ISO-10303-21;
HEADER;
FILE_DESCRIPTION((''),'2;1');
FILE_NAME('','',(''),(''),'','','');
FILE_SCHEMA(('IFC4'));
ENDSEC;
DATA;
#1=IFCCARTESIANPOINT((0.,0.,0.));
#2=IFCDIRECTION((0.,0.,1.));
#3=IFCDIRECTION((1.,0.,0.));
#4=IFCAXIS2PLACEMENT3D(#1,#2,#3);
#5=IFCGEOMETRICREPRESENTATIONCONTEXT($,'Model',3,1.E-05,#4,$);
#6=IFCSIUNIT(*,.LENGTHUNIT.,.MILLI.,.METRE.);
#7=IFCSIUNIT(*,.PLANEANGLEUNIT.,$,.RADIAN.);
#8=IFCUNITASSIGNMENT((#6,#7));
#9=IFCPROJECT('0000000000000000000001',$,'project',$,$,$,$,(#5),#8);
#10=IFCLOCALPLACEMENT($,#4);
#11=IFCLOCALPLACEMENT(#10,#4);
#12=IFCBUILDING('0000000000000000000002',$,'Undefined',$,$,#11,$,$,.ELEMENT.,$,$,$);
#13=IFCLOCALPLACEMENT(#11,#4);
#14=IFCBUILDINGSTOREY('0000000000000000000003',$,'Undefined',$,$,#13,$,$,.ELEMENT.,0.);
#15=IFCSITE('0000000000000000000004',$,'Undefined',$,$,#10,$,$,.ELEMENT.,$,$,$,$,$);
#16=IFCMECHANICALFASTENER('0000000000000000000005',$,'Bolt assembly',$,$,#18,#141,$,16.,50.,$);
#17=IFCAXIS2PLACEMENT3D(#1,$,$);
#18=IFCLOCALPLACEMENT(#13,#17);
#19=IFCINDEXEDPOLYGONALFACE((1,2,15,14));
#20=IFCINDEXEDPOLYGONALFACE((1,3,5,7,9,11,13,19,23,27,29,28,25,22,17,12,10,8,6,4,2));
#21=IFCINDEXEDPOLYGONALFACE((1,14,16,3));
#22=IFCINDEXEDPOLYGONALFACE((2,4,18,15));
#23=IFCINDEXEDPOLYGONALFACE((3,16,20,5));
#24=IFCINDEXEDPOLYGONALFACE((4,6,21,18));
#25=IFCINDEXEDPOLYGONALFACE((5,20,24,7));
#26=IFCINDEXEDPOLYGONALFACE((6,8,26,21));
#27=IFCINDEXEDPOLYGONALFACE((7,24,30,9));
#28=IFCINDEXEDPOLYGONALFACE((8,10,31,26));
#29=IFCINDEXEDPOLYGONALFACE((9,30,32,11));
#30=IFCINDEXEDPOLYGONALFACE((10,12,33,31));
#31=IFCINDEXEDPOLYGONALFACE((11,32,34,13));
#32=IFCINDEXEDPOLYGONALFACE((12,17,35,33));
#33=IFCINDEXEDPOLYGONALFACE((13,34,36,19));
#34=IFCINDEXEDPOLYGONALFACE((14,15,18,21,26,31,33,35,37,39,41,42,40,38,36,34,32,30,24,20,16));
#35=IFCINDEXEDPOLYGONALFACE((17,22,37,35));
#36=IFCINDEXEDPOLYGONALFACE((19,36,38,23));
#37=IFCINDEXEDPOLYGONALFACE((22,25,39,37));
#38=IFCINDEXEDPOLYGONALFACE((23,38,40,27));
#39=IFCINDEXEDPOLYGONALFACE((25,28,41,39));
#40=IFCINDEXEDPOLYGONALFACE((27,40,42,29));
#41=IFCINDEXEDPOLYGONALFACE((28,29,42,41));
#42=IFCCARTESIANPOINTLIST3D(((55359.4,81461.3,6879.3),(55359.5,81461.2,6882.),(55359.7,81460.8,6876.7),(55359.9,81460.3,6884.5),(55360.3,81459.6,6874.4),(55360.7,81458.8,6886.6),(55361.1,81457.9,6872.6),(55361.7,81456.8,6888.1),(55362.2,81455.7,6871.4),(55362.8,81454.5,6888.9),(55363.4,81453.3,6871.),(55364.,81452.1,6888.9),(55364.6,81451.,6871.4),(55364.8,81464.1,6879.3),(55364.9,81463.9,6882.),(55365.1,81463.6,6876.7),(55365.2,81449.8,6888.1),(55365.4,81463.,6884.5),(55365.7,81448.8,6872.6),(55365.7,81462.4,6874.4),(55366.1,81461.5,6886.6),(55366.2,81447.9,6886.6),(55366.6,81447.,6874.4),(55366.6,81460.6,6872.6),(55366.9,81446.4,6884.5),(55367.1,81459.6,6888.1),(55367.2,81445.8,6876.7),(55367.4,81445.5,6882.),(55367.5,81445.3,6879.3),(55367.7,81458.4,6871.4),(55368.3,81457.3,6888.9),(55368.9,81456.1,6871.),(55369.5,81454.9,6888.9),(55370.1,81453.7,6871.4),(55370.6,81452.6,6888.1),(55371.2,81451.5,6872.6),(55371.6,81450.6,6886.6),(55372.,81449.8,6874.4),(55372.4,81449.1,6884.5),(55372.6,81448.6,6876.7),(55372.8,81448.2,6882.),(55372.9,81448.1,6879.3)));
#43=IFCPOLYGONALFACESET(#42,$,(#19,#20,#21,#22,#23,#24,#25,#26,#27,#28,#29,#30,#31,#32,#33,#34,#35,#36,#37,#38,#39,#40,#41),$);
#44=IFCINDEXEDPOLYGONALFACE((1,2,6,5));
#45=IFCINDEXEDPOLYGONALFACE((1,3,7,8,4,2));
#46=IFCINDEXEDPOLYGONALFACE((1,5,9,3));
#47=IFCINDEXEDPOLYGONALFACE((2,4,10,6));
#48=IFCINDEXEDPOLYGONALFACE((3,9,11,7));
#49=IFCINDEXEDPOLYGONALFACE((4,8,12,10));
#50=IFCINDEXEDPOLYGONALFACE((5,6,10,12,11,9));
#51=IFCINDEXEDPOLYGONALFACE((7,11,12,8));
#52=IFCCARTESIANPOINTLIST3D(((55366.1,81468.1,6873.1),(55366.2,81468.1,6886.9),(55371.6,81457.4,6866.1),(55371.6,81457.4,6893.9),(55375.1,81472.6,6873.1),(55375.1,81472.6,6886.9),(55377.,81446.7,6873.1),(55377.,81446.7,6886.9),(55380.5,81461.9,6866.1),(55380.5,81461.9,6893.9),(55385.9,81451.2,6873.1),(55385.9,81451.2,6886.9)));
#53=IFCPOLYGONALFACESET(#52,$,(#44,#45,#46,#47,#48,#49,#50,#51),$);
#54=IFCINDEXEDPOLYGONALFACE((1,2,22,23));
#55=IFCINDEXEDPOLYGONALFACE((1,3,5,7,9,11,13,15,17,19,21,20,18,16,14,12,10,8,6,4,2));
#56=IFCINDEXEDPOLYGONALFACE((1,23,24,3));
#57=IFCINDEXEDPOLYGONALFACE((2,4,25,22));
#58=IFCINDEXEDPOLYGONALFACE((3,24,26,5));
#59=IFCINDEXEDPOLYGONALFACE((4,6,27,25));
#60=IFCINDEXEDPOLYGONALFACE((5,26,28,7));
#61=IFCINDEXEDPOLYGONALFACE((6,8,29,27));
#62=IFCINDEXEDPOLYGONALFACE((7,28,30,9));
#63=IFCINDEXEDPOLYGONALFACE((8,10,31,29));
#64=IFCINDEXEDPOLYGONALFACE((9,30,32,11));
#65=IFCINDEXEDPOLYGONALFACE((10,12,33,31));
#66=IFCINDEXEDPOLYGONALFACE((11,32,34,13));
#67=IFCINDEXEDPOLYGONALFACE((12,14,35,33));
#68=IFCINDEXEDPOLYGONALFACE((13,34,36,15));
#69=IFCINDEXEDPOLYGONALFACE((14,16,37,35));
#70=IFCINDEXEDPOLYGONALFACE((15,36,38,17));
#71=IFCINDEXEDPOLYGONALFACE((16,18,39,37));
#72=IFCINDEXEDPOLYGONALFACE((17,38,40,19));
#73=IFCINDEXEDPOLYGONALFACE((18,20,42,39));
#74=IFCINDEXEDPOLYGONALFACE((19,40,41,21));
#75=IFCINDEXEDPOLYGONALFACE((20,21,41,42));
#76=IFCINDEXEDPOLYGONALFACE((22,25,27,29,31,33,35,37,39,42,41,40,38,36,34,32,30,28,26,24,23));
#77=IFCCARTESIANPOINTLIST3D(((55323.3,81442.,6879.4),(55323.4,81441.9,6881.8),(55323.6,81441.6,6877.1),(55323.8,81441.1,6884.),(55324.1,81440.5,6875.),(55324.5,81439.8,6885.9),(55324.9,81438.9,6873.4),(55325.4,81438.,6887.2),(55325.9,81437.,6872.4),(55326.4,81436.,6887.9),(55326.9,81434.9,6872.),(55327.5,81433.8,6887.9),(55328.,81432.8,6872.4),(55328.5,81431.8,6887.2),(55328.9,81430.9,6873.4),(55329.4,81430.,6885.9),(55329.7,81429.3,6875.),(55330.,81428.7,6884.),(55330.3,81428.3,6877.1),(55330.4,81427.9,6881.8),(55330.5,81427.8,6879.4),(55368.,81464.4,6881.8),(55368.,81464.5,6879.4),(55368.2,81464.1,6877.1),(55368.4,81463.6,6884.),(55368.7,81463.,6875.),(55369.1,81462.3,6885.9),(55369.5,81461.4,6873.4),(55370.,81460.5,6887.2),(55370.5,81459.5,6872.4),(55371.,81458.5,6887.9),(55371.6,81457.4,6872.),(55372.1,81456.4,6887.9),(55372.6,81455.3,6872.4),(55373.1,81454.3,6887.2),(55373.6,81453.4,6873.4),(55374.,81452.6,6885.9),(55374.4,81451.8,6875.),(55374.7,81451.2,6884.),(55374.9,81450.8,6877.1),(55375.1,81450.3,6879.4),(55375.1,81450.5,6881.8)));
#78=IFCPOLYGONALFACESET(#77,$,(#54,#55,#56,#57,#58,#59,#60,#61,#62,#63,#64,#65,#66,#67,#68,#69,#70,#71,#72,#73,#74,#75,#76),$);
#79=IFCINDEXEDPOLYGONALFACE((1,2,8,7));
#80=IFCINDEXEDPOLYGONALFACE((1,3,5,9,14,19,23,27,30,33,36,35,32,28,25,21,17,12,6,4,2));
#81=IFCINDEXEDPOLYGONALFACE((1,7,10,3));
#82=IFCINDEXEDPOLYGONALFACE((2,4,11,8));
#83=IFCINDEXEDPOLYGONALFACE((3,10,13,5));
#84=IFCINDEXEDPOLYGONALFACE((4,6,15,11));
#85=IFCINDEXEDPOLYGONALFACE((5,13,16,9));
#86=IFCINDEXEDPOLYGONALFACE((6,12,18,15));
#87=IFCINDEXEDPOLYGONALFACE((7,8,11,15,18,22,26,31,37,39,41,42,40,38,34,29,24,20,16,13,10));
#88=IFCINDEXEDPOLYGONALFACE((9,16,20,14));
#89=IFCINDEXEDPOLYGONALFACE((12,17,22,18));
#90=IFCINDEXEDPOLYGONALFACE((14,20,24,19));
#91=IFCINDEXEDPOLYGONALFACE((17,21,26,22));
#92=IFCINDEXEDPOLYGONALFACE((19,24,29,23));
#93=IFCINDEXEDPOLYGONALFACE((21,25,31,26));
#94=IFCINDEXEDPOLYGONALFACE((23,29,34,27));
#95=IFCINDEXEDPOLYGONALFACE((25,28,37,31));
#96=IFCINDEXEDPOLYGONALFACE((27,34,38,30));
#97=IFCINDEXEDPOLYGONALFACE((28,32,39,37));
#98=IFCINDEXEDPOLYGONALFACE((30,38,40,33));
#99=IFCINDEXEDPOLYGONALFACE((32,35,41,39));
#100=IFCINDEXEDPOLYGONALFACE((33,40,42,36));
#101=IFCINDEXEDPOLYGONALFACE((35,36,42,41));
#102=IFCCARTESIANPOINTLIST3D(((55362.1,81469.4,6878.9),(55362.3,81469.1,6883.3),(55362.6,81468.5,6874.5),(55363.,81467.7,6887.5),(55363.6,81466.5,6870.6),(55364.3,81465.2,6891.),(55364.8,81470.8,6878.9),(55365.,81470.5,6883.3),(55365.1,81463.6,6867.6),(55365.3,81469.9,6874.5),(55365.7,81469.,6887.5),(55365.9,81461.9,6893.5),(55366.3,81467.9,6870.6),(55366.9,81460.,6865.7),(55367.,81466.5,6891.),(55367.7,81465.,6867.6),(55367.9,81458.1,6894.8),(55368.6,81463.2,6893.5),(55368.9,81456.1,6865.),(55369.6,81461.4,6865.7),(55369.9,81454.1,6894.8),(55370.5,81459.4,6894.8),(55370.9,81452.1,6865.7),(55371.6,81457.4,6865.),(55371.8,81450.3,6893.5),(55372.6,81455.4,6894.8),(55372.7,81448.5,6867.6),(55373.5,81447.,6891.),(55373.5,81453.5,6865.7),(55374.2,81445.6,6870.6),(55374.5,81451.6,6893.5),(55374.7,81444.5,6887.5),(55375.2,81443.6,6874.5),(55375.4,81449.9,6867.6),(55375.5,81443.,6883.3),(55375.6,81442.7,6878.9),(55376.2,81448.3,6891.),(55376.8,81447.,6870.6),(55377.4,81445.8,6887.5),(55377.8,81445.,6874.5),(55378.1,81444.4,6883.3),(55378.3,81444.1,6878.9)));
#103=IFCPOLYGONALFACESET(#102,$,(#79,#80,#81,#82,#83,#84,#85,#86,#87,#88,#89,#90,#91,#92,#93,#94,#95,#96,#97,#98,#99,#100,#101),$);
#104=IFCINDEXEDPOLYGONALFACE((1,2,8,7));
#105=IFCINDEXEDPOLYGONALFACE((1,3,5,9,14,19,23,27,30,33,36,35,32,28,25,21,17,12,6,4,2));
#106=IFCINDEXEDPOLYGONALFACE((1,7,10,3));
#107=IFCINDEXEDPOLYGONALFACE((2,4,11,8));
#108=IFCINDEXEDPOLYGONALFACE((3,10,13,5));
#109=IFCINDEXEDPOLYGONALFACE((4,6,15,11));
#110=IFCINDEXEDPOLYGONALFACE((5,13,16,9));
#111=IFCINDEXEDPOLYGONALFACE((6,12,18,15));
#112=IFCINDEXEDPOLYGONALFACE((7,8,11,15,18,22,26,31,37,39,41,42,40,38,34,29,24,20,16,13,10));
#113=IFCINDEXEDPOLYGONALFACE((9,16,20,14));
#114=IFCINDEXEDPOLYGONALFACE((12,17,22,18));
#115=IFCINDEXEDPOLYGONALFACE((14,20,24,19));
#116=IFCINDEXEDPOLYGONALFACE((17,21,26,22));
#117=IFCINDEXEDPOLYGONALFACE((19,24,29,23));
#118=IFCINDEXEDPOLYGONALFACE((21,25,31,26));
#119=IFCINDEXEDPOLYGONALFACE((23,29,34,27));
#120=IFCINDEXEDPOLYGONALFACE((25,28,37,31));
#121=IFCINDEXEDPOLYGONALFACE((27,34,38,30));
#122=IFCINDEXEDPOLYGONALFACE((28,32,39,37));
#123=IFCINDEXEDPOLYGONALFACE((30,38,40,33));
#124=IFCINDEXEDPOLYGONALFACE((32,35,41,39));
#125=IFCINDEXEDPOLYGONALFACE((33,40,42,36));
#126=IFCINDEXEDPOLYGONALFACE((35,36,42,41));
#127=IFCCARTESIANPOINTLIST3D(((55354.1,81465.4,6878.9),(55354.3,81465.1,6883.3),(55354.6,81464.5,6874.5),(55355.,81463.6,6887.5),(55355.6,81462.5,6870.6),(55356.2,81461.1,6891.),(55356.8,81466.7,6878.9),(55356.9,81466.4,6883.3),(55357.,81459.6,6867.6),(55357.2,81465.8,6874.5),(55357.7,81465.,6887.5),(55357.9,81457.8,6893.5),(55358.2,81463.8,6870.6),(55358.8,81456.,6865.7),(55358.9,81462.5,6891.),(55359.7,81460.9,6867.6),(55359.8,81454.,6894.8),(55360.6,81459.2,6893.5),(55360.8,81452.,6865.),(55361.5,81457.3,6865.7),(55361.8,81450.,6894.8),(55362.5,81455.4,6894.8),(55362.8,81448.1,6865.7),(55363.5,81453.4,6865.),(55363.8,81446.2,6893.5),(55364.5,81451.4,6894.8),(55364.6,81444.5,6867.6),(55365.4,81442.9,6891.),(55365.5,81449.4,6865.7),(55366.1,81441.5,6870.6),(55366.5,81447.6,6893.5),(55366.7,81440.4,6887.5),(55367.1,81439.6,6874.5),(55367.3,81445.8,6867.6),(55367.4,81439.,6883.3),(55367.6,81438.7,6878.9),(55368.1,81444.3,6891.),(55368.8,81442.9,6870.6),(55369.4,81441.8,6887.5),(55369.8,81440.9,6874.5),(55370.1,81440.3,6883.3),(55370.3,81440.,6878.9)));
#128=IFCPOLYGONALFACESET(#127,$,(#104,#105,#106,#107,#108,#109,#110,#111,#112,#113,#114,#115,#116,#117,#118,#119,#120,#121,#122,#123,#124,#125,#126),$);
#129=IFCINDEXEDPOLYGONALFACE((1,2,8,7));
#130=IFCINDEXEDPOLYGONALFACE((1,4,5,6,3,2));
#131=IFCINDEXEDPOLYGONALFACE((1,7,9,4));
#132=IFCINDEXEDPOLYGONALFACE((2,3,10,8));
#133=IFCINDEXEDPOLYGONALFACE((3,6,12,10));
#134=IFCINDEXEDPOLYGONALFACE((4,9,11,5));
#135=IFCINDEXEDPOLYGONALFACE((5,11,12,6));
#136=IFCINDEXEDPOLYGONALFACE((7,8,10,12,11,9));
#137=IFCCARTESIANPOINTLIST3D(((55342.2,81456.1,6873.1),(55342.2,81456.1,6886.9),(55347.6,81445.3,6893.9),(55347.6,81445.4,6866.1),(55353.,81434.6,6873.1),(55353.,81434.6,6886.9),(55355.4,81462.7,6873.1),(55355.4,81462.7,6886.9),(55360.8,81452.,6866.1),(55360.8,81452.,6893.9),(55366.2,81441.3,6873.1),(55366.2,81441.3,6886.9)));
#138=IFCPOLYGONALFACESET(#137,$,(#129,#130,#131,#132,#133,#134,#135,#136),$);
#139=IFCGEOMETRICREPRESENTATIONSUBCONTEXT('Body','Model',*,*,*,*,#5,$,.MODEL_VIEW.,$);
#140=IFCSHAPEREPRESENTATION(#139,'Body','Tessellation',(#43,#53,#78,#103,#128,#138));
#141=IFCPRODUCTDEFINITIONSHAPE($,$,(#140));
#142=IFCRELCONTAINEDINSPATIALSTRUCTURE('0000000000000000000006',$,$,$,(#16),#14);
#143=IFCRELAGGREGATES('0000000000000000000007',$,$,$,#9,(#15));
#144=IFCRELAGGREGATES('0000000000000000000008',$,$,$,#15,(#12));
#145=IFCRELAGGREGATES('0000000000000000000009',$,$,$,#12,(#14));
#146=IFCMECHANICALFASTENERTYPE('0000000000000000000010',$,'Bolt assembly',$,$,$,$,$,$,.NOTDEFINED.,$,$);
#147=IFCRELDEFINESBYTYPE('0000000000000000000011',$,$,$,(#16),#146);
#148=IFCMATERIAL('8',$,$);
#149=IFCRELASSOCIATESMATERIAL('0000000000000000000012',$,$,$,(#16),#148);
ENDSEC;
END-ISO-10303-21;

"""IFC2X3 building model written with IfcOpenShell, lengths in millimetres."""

from ifc_helpers import new_model, si_unit, frame, origin_with_axes, origin_2d_with_axis, place, context, subcontext, project, spatial, polyline, circle, outline, extrude, source, transform, mapped, material, type_object, element, save


model = new_model("IFC2X3")

# Units and contexts
model_context = context("Model", 3, precision=1e-05, world=origin_with_axes())
body_context = subcontext(model_context, "Body", "Model", "MODEL_VIEW")
ifc_project = project(units=[si_unit("LENGTHUNIT", "METRE", prefix="MILLI"), si_unit("PLANEANGLEUNIT", "RADIAN")], contexts=[model_context])

# Site, building, storey
site_placement = place(None, origin_with_axes())
site = spatial("IfcSite", under=ifc_project, at=site_placement, Name="Undefined", CompositionType="ELEMENT")
building_placement = place(site_placement, origin_with_axes())
building = spatial("IfcBuilding", under=site, at=building_placement, Name="Undefined", CompositionType="ELEMENT")
storey_placement = place(building_placement, origin_with_axes())
storey = spatial("IfcBuildingStorey", under=building, at=storey_placement, Name="Undefined", CompositionType="ELEMENT", Elevation=0.0)

# Mechanical fastener
ifc_material_1 = material(Name="8")
mechanical_fastener_type = type_object("IfcMechanicalFastenerType", Name="Bolt assembly")
shared_shape_1 = source(origin_with_axes(), body_context, "Body", "SweptSolid", [
    extrude(circle(Radius=9.0, at=origin_2d_with_axis()), frame((0.0, 0.0, 0.0), z_axis=(0.0, 1.0, 0.0), x_axis=(1.0, 0.0, 0.0)), (0.0, 0.0, 1.0), 6.1),
    extrude(outline(polyline([(13.9, 0.0), (6.9, 12.0), (-6.9, 12.0), (-13.9, 0.0), (-6.9, -12.0), (6.9, -12.0), (13.9, 0.0)])), frame((0.0, -13.0, 0.0), z_axis=(0.0, 1.0, 0.0), x_axis=(1.0, 0.0, 0.0)), (0.0, 0.0, 1.0), 10.0),
    extrude(circle(Radius=8.0, at=origin_2d_with_axis()), frame((0.0, -3.0, 0.0), z_axis=(0.0, 1.0, 0.0), x_axis=(1.0, 0.0, 0.0)), (0.0, 0.0, 1.0), 50.0),
    extrude(circle(Radius=15.0, at=origin_2d_with_axis()), frame((0.0, -3.0, 0.0), z_axis=(0.0, 1.0, 0.0), x_axis=(1.0, 0.0, 0.0)), (0.0, 0.0, 1.0), 3.0),
    extrude(circle(Radius=15.0, at=origin_2d_with_axis()), frame((0.0, 6.0, 0.0), z_axis=(0.0, 1.0, 0.0), x_axis=(1.0, 0.0, 0.0)), (0.0, 0.0, 1.0), 3.0),
    extrude(outline(polyline([(13.9, 0.0), (6.9, 12.0), (-6.9, 12.0), (-13.9, 0.0), (-6.9, -12.0), (6.9, -12.0), (13.9, 0.0)])), frame((0.0, 9.0, 0.0), z_axis=(0.0, 1.0, 0.0), x_axis=(1.0, 0.0, 0.0)), (0.0, 0.0, 1.0), 14.8),
])
mechanical_fastener_1_placement = place(storey_placement, frame((55368.9, 81456.1, 6880.0), z_axis=(-0.45041, 0.892822, 0.000127), x_axis=(-0.000057, 0.000114, -1.0)))
element("IfcMechanicalFastener", 1, at=mechanical_fastener_1_placement, inside=storey, type_object=mechanical_fastener_type, material=ifc_material_1, Name="Bolt assembly", NominalDiameter=16.0, NominalLength=50.0, context=body_context, shape_type="MappedRepresentation", body=[
    mapped(shared_shape_1, transform((0.0, 0.0, 0.0))),
])

save(model, "model.ifc")
